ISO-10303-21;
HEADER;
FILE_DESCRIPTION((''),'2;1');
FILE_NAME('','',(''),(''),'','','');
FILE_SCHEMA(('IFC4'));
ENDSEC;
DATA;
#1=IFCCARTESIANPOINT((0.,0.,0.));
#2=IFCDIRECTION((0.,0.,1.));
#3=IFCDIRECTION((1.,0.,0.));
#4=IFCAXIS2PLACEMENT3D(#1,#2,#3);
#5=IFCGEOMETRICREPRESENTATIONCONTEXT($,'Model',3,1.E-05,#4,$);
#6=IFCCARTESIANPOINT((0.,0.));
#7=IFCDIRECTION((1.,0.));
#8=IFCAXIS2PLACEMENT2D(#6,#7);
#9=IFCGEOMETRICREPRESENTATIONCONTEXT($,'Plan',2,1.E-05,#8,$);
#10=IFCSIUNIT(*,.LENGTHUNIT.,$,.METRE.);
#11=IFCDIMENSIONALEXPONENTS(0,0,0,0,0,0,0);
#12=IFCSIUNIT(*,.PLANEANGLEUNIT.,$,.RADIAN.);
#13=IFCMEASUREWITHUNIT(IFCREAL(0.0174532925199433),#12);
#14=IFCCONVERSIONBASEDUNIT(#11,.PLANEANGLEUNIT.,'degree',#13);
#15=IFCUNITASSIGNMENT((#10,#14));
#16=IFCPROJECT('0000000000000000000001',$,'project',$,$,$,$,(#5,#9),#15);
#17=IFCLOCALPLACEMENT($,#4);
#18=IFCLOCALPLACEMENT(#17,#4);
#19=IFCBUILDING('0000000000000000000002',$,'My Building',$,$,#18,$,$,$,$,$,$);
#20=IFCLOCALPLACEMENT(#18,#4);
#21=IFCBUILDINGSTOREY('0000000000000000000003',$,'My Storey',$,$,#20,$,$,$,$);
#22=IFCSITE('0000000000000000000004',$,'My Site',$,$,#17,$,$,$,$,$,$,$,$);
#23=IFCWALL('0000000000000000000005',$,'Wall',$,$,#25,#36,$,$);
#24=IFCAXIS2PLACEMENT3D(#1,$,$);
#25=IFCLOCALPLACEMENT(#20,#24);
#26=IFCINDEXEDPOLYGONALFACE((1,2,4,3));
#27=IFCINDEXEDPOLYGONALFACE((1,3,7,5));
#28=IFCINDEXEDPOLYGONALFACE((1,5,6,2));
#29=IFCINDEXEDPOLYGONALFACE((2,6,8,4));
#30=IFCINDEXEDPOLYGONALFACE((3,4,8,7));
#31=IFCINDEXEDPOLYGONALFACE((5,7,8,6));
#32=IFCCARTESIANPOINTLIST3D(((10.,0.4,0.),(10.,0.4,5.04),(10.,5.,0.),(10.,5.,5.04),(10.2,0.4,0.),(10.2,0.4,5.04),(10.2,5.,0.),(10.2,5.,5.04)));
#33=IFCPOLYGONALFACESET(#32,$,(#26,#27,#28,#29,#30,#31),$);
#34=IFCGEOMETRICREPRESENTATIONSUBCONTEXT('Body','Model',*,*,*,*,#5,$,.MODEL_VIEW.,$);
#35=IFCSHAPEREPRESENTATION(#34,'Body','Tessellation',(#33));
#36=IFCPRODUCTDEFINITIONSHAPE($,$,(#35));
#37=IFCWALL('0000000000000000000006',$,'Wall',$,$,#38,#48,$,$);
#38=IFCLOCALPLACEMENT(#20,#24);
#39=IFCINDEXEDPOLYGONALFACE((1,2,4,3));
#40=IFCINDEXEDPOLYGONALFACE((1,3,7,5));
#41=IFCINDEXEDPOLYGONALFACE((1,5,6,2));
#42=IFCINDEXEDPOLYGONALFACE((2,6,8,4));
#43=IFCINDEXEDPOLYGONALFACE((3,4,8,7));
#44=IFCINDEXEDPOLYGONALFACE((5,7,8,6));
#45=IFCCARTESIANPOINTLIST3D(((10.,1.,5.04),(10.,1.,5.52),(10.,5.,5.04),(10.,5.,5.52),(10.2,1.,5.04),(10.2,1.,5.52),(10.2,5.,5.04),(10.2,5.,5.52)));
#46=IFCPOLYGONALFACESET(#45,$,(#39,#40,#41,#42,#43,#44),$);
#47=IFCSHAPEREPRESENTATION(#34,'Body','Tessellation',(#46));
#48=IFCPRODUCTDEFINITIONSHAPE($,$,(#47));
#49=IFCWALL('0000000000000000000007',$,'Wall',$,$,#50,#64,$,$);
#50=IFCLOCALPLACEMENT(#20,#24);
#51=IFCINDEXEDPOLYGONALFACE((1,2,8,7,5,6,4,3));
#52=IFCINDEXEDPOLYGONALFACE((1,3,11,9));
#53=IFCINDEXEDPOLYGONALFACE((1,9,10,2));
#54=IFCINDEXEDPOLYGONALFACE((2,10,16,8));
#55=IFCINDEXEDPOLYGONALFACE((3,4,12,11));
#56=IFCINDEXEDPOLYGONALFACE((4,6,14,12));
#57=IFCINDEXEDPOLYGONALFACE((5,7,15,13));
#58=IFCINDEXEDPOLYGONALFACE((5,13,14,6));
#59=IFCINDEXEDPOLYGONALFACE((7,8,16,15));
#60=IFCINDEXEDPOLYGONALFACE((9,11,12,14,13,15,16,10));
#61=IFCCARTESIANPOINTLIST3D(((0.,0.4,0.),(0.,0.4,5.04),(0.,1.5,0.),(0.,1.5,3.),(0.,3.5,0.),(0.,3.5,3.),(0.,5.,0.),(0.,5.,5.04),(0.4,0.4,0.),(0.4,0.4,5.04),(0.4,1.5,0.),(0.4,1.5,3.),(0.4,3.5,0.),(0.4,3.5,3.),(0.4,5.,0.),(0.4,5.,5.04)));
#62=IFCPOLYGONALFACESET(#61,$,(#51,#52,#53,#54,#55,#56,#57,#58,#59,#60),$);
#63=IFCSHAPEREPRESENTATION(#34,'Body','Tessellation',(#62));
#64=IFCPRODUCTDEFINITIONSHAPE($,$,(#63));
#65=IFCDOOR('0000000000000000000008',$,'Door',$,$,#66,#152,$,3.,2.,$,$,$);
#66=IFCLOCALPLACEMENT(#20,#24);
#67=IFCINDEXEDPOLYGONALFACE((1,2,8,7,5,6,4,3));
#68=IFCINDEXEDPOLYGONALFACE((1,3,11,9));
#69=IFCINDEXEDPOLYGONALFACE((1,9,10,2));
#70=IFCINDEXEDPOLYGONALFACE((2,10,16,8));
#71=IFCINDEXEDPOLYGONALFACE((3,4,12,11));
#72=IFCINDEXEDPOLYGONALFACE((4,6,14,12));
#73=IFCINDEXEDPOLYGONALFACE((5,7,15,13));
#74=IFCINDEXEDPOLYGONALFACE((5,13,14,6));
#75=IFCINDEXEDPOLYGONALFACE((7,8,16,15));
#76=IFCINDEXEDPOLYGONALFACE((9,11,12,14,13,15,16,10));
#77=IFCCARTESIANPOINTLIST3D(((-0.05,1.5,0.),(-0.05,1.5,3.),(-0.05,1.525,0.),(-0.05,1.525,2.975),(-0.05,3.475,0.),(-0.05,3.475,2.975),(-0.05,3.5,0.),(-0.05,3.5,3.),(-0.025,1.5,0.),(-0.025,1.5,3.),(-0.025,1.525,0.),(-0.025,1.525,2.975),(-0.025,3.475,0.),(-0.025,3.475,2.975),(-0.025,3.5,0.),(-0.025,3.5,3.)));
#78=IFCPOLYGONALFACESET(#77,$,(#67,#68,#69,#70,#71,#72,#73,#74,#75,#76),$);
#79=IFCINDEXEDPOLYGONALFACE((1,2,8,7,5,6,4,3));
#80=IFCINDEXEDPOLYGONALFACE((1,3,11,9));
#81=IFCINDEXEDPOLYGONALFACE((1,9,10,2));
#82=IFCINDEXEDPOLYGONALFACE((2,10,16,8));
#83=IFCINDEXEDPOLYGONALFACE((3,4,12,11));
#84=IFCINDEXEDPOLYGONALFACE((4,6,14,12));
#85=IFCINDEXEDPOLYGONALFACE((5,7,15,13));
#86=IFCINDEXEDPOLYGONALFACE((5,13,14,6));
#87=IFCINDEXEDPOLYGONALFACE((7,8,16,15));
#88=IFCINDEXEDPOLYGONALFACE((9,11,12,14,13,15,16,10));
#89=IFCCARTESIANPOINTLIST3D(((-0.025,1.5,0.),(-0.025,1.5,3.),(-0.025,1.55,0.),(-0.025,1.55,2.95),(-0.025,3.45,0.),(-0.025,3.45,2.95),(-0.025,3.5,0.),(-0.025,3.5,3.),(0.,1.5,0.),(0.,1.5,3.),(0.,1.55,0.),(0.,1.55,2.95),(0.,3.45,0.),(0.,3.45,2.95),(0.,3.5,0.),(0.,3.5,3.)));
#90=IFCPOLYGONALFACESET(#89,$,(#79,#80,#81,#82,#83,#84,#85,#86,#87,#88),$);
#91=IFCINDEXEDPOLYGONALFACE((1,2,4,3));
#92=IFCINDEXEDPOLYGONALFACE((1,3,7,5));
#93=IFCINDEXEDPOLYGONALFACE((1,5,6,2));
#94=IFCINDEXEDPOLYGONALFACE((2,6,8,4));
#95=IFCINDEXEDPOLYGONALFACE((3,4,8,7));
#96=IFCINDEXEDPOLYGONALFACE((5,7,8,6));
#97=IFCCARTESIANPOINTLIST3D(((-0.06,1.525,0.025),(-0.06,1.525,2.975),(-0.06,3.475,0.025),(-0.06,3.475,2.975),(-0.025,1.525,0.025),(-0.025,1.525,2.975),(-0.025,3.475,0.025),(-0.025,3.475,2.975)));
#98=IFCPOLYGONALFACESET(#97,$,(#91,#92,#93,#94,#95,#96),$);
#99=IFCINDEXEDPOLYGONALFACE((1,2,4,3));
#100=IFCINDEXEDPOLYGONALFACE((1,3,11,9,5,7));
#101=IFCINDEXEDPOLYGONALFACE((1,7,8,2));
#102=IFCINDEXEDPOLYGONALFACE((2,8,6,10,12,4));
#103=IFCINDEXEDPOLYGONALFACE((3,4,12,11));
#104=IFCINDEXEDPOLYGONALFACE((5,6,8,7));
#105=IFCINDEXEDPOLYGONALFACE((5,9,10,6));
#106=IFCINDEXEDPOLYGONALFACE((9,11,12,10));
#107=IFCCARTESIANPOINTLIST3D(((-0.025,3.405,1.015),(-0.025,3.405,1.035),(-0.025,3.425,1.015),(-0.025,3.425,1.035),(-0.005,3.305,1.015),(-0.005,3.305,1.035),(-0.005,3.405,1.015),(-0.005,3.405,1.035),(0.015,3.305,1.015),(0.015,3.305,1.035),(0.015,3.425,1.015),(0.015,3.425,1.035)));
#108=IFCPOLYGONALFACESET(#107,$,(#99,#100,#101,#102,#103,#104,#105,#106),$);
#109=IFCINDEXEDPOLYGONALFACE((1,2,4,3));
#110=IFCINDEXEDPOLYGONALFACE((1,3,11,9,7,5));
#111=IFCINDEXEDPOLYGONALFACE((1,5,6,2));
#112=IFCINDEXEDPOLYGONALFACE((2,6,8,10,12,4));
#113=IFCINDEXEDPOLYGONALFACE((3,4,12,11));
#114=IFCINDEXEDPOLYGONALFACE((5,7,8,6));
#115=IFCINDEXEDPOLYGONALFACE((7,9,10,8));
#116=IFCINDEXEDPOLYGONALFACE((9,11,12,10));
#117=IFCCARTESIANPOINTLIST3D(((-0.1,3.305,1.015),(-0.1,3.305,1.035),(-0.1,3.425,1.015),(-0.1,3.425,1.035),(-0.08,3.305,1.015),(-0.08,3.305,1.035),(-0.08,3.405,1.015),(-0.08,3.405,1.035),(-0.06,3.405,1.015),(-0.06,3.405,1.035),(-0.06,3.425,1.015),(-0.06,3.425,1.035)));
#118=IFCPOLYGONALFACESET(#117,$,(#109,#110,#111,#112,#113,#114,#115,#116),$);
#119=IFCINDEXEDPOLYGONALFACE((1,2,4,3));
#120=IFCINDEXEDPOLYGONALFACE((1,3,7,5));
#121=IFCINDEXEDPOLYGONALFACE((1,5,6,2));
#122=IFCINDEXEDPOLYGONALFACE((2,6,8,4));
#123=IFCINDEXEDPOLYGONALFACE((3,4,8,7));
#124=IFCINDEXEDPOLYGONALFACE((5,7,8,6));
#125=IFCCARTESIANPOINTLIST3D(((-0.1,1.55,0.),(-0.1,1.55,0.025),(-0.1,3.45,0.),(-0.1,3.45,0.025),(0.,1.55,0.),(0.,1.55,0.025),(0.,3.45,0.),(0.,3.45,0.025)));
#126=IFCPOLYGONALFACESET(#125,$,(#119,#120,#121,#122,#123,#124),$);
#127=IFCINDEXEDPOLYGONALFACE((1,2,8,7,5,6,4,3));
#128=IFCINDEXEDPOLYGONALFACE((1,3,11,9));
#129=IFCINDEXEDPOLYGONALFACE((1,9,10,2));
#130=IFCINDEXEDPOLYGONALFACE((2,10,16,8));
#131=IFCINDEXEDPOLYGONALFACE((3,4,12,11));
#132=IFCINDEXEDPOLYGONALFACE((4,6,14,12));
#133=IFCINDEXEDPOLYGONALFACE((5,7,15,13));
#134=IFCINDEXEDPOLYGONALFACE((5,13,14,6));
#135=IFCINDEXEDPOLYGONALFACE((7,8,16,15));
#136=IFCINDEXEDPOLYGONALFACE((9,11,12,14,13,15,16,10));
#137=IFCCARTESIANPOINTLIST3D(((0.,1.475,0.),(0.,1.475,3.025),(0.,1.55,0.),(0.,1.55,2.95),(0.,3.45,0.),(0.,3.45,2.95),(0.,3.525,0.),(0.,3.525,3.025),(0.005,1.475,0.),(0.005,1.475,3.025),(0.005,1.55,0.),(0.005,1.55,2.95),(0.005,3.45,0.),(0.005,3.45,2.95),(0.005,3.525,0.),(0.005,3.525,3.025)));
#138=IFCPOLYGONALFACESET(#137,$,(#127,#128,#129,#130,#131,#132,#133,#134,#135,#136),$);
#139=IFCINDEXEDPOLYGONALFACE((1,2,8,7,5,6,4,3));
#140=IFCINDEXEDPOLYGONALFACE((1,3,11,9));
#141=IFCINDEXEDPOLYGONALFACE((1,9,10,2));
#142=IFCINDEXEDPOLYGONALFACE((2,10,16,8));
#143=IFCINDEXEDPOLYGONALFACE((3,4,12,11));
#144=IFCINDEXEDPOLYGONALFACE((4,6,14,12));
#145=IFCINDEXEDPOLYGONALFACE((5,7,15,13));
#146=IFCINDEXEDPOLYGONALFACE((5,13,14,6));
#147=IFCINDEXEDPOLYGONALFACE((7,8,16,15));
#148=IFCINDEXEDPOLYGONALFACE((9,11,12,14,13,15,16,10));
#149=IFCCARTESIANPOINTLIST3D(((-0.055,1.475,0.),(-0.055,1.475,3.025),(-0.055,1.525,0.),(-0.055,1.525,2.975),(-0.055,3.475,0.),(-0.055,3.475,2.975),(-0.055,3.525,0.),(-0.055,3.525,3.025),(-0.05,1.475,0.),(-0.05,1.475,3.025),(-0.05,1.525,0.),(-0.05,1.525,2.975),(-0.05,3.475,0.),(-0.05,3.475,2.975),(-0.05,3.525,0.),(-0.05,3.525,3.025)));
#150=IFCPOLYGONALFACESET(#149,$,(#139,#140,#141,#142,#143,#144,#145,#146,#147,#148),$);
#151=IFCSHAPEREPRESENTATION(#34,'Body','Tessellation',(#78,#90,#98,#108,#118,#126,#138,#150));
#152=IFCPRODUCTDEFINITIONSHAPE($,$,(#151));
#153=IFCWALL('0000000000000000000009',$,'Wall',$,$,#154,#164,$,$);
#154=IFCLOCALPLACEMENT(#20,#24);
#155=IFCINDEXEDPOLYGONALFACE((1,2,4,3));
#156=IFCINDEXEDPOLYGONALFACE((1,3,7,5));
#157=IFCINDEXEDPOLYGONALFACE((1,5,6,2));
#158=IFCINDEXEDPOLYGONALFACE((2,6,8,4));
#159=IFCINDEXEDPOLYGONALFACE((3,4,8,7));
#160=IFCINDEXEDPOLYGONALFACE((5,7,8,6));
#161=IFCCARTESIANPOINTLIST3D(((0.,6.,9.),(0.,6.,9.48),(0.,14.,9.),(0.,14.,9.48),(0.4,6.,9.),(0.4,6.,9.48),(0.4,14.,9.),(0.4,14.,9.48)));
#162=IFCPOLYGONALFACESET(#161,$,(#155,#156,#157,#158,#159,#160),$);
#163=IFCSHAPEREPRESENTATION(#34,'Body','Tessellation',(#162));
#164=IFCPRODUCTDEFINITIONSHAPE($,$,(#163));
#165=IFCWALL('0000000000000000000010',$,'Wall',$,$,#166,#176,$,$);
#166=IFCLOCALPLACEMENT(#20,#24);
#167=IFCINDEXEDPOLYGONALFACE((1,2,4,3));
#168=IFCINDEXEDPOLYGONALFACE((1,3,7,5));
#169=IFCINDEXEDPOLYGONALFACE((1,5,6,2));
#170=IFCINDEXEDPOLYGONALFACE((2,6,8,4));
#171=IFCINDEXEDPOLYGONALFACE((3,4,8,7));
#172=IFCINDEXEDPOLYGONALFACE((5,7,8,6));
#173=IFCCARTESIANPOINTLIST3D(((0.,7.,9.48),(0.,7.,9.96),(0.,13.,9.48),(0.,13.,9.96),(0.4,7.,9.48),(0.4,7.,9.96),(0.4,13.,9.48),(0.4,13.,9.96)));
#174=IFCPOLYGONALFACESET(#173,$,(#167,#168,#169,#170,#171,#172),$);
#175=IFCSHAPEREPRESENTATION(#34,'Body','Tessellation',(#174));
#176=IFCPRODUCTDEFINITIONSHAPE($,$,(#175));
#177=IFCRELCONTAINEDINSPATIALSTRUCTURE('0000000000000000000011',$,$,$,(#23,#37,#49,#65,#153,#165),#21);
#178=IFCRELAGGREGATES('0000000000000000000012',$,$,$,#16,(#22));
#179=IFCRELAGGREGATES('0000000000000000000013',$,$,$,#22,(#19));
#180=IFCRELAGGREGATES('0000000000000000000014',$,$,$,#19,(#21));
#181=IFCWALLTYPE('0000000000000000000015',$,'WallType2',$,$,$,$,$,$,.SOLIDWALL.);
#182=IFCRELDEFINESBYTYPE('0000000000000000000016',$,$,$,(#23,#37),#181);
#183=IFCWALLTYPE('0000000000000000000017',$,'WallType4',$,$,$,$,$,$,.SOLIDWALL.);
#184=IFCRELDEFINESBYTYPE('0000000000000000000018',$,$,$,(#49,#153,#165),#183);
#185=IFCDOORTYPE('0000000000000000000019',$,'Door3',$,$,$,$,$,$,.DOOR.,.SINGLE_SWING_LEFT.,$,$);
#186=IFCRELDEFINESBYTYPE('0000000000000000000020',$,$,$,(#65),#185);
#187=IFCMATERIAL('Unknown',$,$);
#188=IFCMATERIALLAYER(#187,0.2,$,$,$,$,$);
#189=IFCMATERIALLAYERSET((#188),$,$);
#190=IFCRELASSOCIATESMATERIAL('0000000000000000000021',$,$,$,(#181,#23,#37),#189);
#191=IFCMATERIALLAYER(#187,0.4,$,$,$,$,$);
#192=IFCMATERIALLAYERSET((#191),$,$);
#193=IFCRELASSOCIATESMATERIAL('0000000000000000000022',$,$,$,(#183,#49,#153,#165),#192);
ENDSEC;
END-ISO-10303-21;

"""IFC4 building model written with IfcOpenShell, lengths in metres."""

from ifc_helpers import new_model, entity, si_unit, converted_unit, frame, origin_with_axes, origin_2d_with_axis, place, context, subcontext, project, spatial, line, indexed_curve, outline, extrude, shape, source, transform, mapped, material, layer, layer_set, layer_usage, type_object, type_shapes, element, fill, save


model = new_model("IFC4")

# Units and contexts
model_context = context("Model", 3, precision=1e-05, world=origin_with_axes())
plan_context = context("Plan", 2, precision=1e-05, world=origin_2d_with_axis())
body_context_1 = subcontext(model_context, "Body", "Model", "MODEL_VIEW")
body_context_2 = subcontext(plan_context, "Body", "Plan", "PLAN_VIEW")
ifc_project = project(units=[si_unit("LENGTHUNIT", "METRE"), converted_unit("PLANEANGLEUNIT", "degree", entity("IfcReal", 0.0174532925199433), si_unit("PLANEANGLEUNIT", "RADIAN"), dimensions=[0, 0, 0, 0, 0, 0, 0])], contexts=[model_context, plan_context])

# Site, building, storey
site_placement = place(None, origin_with_axes())
site = spatial("IfcSite", under=ifc_project, at=site_placement, Name="My Site")
building_placement = place(site_placement, origin_with_axes())
building = spatial("IfcBuilding", under=site, at=building_placement, Name="My Building")
storey_placement = place(building_placement, origin_with_axes())
storey = spatial("IfcBuildingStorey", under=building, at=storey_placement, Name="My Storey")

# Walls
ifc_material = material(Name="Unknown")
ifc_layer_1 = layer(ifc_material, 0.2)
ifc_layer_set_1 = layer_set([ifc_layer_1])
ifc_layer_usage_1 = layer_usage(ifc_layer_set_1, "AXIS2", "POSITIVE", 0.0)
wall_type_1 = type_object("IfcWallType", Name="WallType2", PredefinedType="SOLIDWALL", material=ifc_layer_set_1)
wall_1_placement = place(storey_placement, frame((10.2, 0.4, 0.0), z_axis=(0.0, 0.0, 1.0), x_axis=(0.0, 1.0, 0.0)))
element("IfcWall", 1, at=wall_1_placement, inside=storey, type_object=wall_type_1, material=ifc_layer_usage_1, Name="Wall", context=body_context_1, shape_type="SweptSolid", body=[
    extrude(outline(indexed_curve([(0.0, 0.0), (0.0, 0.2), (4.6, 0.2), (4.6, 0.0), (0.0, 0.0)], self_intersect=False)), origin_with_axes(), (0.0, 0.0, 1.0), 5.04),
])
ifc_layer_usage_2 = layer_usage(ifc_layer_set_1, "AXIS2", "POSITIVE", 0.0)
wall_2_placement = place(storey_placement, frame((10.2, 1.0, 5.04), z_axis=(0.0, 0.0, 1.0), x_axis=(0.0, 1.0, 0.0)))
element("IfcWall", 2, at=wall_2_placement, inside=storey, type_object=wall_type_1, material=ifc_layer_usage_2, Name="Wall", context=body_context_1, shape_type="SweptSolid", body=[
    extrude(outline(indexed_curve([(0.0, 0.0), (0.0, 0.2), (4.0, 0.2), (4.0, 0.0), (0.0, 0.0)], self_intersect=False)), origin_with_axes(), (0.0, 0.0, 1.0), 0.48),
])

# Shared definitions
ifc_layer_2 = layer(ifc_material, 0.4)
ifc_layer_set_2 = layer_set([ifc_layer_2])
wall_type_2 = type_object("IfcWallType", Name="WallType4", PredefinedType="SOLIDWALL", material=ifc_layer_set_2)

# Wall, opening, door
ifc_layer_usage_3 = layer_usage(ifc_layer_set_2, "AXIS2", "POSITIVE", 0.0)
wall_3_placement = place(storey_placement, frame((0.4, 0.4, 0.0), z_axis=(0.0, 0.0, 1.0), x_axis=(0.0, 1.0, 0.0)))
wall_3 = element("IfcWall", 3, at=wall_3_placement, inside=storey, type_object=wall_type_2, material=ifc_layer_usage_3, Name="Wall", context=body_context_1, shape_type="SweptSolid", body=[
    extrude(outline(indexed_curve([(0.0, 0.0), (0.0, 0.4), (4.6, 0.4), (4.6, 0.0), (0.0, 0.0)], self_intersect=False)), origin_with_axes(), (0.0, 0.0, 1.0), 5.04),
])
shared_shape_1 = source(origin_with_axes(), body_context_1, "Body", "SweptSolid", [
    extrude(outline(indexed_curve([(0.0, 0.0), (2.0, 0.0), (2.0, 3.0), (0.0, 3.0)], segments=[line(1, 2, 3, 4, 1)])), frame((0.0, -0.6, 0.0), z_axis=(0.0, -1.0, 0.0), x_axis=(1.0, 0.0, 0.0)), (0.0, 0.0, -1.0), 1.2),
])
opening_1_placement = place(wall_3_placement, frame((1.1, 0.0, 0.0), z_axis=(0.0, 0.0, 1.0), x_axis=(1.0, 0.0, 0.0)))
opening_1 = element("IfcOpeningElement", 4, at=opening_1_placement, cuts=wall_3, PredefinedType="OPENING", context=body_context_1, shape_type="MappedRepresentation", body=[
    mapped(shared_shape_1, transform((0.0, 0.0, 0.0), x_axis=(1.0, 0.0, 0.0), y_axis=(0.0, 1.0, 0.0), z_axis=(0.0, 0.0, 1.0), scale=1.0)),
])
door_type_1 = type_object("IfcDoorType", Name="Door3", OperationType="SINGLE_SWING_LEFT", PredefinedType="DOOR")
shared_shape_2 = source(origin_with_axes(), body_context_1, "Body", "SweptSolid", [
    extrude(outline(indexed_curve([(0.0, 0.0), (0.0, 3.0), (2.0, 3.0), (2.0, 0.0), (1.975, 0.0), (1.975, 2.975), (0.025, 2.975), (0.025, 0.0)], segments=[line(1, 2, 3, 4, 5, 6, 7, 8, 1)])), frame((0.0, 0.025, 0.0), z_axis=(0.0, -1.0, 0.0), x_axis=(1.0, 0.0, 0.0)), (0.0, 0.0, -1.0), 0.025),
    extrude(outline(indexed_curve([(0.0, 0.0), (0.0, 3.0), (2.0, 3.0), (2.0, 0.0), (1.95, 0.0), (1.95, 2.95), (0.05, 2.95), (0.05, 0.0)], segments=[line(1, 2, 3, 4, 5, 6, 7, 8, 1)])), frame((0.0, 0.0, 0.0), z_axis=(0.0, -1.0, 0.0), x_axis=(1.0, 0.0, 0.0)), (0.0, 0.0, -1.0), 0.025),
    extrude(outline(indexed_curve([(0.0, 0.0), (1.95, 0.0), (1.95, 0.035), (0.0, 0.035)], segments=[line(1, 2, 3, 4, 1)])), frame((0.025, 0.025, 0.025), z_axis=(0.0, 0.0, 1.0), x_axis=(1.0, 0.0, 0.0)), (0.0, 0.0, 1.0), 2.95),
    extrude(outline(indexed_curve([(0.0, 0.0), (0.0, -0.04), (-0.12, -0.04), (-0.12, -0.02), (-0.02, -0.02), (-0.02, 0.0)], segments=[line(1, 2, 3, 4, 5, 6, 1)])), frame((1.925, 0.025, 1.015), z_axis=(0.0, 0.0, 1.0), x_axis=(1.0, 0.0, 0.0)), (0.0, 0.0, 1.0), 0.02),
    extrude(outline(indexed_curve([(0.0, 0.0), (0.0, 0.04), (-0.12, 0.04), (-0.12, 0.02), (-0.02, 0.02), (-0.02, 0.0)], segments=[line(1, 2, 3, 4, 5, 6, 1)])), frame((1.925, 0.06, 1.015), z_axis=(0.0, 0.0, 1.0), x_axis=(1.0, 0.0, 0.0)), (0.0, 0.0, 1.0), 0.02),
    extrude(outline(indexed_curve([(0.0, 0.0), (1.9, 0.0), (1.9, 0.1), (0.0, 0.1)], segments=[line(1, 2, 3, 4, 1)])), frame((0.05, 0.0, 0.0), z_axis=(0.0, 0.0, 1.0), x_axis=(1.0, 0.0, 0.0)), (0.0, 0.0, 1.0), 0.025),
    extrude(outline(indexed_curve([(0.0, 0.0), (0.0, 3.025), (2.05, 3.025), (2.05, 0.0), (1.975, 0.0), (1.975, 2.95), (0.075, 2.95), (0.075, 0.0)], segments=[line(1, 2, 3, 4, 5, 6, 7, 8, 1)])), frame((-0.025, -0.005, 0.0), z_axis=(0.0, -1.0, 0.0), x_axis=(1.0, 0.0, 0.0)), (0.0, 0.0, -1.0), 0.005),
    extrude(outline(indexed_curve([(0.0, 0.0), (0.0, 3.025), (2.05, 3.025), (2.05, 0.0), (2.0, 0.0), (2.0, 2.975), (0.05, 2.975), (0.05, 0.0)], segments=[line(1, 2, 3, 4, 5, 6, 7, 8, 1)])), frame((-0.025, 0.05, 0.0), z_axis=(0.0, -1.0, 0.0), x_axis=(1.0, 0.0, 0.0)), (0.0, 0.0, -1.0), 0.005),
])
shared_shape_3 = source(origin_with_axes(), body_context_2, "Body", "Curve2D", [
    entity("IfcIndexedPolyCurve", entity("IfcCartesianPointList2D", [[0.0, 0.0], [0.0, 0.05], [0.025, 0.05], [0.025, 0.025], [0.05, 0.025], [0.05, 0.0]]), [entity("IfcLineIndex", [1, 2, 3, 4, 5, 6, 1])]),
    entity("IfcIndexedPolyCurve", entity("IfcCartesianPointList2D", [[2.0, 0.0], [2.0, 0.05], [1.975, 0.05], [1.975, 0.025], [1.95, 0.025], [1.95, 0.0]]), [entity("IfcLineIndex", [1, 2, 3, 4, 5, 6, 1])]),
    entity("IfcTrimmedCurve", entity("IfcEllipse", entity("IfcAxis2Placement2D", entity("IfcCartesianPoint", [0.06, 0.05]), entity("IfcDirection", [1.0, 0.0])), 1.915, 1.95), [entity("IfcCartesianPoint", [1.975, 0.05])], [entity("IfcCartesianPoint", [0.06, 2.0])], True, "CARTESIAN"),
    entity("IfcIndexedPolyCurve", entity("IfcCartesianPointList2D", [[0.025, 0.05], [0.06, 0.05], [0.06, 2.0], [0.025, 2.0]]), [entity("IfcLineIndex", [1, 2, 3, 4, 1])]),
])
type_shapes(door_type_1, [shared_shape_2, shared_shape_3])
door_1_placement = place(opening_1_placement, frame((0.0, 0.4, 0.0), z_axis=(0.0, 0.0, 1.0), x_axis=(1.0, 0.0, 0.0)))
door_1 = element("IfcDoor", 5, at=door_1_placement, inside=storey, type_object=door_type_1, Name="Door", OverallHeight=3.0, OverallWidth=2.0, shapes=[
    shape(body_context_1, "Body", "MappedRepresentation", [mapped(shared_shape_2, transform((0.0, 0.0, 0.0), x_axis=(1.0, 0.0, 0.0), y_axis=(0.0, 1.0, 0.0), z_axis=(0.0, 0.0, 1.0), scale=1.0))]),
    shape(body_context_2, "Body", "MappedRepresentation", [mapped(shared_shape_3, transform((0.0, 0.0, 0.0), x_axis=(1.0, 0.0, 0.0), y_axis=(0.0, 1.0, 0.0), z_axis=(0.0, 0.0, 1.0), scale=1.0))]),
])
fill(opening_1, door_1)

# Walls
ifc_layer_usage_4 = layer_usage(ifc_layer_set_2, "AXIS2", "POSITIVE", 0.0)
wall_4_placement = place(storey_placement, frame((0.4, 6.0, 9.0), z_axis=(0.0, 0.0, 1.0), x_axis=(0.0, 1.0, 0.0)))
element("IfcWall", 6, at=wall_4_placement, inside=storey, type_object=wall_type_2, material=ifc_layer_usage_4, Name="Wall", context=body_context_1, shape_type="SweptSolid", body=[
    extrude(outline(indexed_curve([(0.0, 0.0), (0.0, 0.4), (8.0, 0.4), (8.0, 0.0), (0.0, 0.0)], self_intersect=False)), origin_with_axes(), (0.0, 0.0, 1.0), 0.48),
])
ifc_layer_usage_5 = layer_usage(ifc_layer_set_2, "AXIS2", "POSITIVE", 0.0)
wall_5_placement = place(storey_placement, frame((0.4, 7.0, 9.48), z_axis=(0.0, 0.0, 1.0), x_axis=(0.0, 1.0, 0.0)))
element("IfcWall", 7, at=wall_5_placement, inside=storey, type_object=wall_type_2, material=ifc_layer_usage_5, Name="Wall", context=body_context_1, shape_type="SweptSolid", body=[
    extrude(outline(indexed_curve([(0.0, 0.0), (0.0, 0.4), (6.0, 0.4), (6.0, 0.0), (0.0, 0.0)], self_intersect=False)), origin_with_axes(), (0.0, 0.0, 1.0), 0.48),
])

save(model, "model.ifc")
